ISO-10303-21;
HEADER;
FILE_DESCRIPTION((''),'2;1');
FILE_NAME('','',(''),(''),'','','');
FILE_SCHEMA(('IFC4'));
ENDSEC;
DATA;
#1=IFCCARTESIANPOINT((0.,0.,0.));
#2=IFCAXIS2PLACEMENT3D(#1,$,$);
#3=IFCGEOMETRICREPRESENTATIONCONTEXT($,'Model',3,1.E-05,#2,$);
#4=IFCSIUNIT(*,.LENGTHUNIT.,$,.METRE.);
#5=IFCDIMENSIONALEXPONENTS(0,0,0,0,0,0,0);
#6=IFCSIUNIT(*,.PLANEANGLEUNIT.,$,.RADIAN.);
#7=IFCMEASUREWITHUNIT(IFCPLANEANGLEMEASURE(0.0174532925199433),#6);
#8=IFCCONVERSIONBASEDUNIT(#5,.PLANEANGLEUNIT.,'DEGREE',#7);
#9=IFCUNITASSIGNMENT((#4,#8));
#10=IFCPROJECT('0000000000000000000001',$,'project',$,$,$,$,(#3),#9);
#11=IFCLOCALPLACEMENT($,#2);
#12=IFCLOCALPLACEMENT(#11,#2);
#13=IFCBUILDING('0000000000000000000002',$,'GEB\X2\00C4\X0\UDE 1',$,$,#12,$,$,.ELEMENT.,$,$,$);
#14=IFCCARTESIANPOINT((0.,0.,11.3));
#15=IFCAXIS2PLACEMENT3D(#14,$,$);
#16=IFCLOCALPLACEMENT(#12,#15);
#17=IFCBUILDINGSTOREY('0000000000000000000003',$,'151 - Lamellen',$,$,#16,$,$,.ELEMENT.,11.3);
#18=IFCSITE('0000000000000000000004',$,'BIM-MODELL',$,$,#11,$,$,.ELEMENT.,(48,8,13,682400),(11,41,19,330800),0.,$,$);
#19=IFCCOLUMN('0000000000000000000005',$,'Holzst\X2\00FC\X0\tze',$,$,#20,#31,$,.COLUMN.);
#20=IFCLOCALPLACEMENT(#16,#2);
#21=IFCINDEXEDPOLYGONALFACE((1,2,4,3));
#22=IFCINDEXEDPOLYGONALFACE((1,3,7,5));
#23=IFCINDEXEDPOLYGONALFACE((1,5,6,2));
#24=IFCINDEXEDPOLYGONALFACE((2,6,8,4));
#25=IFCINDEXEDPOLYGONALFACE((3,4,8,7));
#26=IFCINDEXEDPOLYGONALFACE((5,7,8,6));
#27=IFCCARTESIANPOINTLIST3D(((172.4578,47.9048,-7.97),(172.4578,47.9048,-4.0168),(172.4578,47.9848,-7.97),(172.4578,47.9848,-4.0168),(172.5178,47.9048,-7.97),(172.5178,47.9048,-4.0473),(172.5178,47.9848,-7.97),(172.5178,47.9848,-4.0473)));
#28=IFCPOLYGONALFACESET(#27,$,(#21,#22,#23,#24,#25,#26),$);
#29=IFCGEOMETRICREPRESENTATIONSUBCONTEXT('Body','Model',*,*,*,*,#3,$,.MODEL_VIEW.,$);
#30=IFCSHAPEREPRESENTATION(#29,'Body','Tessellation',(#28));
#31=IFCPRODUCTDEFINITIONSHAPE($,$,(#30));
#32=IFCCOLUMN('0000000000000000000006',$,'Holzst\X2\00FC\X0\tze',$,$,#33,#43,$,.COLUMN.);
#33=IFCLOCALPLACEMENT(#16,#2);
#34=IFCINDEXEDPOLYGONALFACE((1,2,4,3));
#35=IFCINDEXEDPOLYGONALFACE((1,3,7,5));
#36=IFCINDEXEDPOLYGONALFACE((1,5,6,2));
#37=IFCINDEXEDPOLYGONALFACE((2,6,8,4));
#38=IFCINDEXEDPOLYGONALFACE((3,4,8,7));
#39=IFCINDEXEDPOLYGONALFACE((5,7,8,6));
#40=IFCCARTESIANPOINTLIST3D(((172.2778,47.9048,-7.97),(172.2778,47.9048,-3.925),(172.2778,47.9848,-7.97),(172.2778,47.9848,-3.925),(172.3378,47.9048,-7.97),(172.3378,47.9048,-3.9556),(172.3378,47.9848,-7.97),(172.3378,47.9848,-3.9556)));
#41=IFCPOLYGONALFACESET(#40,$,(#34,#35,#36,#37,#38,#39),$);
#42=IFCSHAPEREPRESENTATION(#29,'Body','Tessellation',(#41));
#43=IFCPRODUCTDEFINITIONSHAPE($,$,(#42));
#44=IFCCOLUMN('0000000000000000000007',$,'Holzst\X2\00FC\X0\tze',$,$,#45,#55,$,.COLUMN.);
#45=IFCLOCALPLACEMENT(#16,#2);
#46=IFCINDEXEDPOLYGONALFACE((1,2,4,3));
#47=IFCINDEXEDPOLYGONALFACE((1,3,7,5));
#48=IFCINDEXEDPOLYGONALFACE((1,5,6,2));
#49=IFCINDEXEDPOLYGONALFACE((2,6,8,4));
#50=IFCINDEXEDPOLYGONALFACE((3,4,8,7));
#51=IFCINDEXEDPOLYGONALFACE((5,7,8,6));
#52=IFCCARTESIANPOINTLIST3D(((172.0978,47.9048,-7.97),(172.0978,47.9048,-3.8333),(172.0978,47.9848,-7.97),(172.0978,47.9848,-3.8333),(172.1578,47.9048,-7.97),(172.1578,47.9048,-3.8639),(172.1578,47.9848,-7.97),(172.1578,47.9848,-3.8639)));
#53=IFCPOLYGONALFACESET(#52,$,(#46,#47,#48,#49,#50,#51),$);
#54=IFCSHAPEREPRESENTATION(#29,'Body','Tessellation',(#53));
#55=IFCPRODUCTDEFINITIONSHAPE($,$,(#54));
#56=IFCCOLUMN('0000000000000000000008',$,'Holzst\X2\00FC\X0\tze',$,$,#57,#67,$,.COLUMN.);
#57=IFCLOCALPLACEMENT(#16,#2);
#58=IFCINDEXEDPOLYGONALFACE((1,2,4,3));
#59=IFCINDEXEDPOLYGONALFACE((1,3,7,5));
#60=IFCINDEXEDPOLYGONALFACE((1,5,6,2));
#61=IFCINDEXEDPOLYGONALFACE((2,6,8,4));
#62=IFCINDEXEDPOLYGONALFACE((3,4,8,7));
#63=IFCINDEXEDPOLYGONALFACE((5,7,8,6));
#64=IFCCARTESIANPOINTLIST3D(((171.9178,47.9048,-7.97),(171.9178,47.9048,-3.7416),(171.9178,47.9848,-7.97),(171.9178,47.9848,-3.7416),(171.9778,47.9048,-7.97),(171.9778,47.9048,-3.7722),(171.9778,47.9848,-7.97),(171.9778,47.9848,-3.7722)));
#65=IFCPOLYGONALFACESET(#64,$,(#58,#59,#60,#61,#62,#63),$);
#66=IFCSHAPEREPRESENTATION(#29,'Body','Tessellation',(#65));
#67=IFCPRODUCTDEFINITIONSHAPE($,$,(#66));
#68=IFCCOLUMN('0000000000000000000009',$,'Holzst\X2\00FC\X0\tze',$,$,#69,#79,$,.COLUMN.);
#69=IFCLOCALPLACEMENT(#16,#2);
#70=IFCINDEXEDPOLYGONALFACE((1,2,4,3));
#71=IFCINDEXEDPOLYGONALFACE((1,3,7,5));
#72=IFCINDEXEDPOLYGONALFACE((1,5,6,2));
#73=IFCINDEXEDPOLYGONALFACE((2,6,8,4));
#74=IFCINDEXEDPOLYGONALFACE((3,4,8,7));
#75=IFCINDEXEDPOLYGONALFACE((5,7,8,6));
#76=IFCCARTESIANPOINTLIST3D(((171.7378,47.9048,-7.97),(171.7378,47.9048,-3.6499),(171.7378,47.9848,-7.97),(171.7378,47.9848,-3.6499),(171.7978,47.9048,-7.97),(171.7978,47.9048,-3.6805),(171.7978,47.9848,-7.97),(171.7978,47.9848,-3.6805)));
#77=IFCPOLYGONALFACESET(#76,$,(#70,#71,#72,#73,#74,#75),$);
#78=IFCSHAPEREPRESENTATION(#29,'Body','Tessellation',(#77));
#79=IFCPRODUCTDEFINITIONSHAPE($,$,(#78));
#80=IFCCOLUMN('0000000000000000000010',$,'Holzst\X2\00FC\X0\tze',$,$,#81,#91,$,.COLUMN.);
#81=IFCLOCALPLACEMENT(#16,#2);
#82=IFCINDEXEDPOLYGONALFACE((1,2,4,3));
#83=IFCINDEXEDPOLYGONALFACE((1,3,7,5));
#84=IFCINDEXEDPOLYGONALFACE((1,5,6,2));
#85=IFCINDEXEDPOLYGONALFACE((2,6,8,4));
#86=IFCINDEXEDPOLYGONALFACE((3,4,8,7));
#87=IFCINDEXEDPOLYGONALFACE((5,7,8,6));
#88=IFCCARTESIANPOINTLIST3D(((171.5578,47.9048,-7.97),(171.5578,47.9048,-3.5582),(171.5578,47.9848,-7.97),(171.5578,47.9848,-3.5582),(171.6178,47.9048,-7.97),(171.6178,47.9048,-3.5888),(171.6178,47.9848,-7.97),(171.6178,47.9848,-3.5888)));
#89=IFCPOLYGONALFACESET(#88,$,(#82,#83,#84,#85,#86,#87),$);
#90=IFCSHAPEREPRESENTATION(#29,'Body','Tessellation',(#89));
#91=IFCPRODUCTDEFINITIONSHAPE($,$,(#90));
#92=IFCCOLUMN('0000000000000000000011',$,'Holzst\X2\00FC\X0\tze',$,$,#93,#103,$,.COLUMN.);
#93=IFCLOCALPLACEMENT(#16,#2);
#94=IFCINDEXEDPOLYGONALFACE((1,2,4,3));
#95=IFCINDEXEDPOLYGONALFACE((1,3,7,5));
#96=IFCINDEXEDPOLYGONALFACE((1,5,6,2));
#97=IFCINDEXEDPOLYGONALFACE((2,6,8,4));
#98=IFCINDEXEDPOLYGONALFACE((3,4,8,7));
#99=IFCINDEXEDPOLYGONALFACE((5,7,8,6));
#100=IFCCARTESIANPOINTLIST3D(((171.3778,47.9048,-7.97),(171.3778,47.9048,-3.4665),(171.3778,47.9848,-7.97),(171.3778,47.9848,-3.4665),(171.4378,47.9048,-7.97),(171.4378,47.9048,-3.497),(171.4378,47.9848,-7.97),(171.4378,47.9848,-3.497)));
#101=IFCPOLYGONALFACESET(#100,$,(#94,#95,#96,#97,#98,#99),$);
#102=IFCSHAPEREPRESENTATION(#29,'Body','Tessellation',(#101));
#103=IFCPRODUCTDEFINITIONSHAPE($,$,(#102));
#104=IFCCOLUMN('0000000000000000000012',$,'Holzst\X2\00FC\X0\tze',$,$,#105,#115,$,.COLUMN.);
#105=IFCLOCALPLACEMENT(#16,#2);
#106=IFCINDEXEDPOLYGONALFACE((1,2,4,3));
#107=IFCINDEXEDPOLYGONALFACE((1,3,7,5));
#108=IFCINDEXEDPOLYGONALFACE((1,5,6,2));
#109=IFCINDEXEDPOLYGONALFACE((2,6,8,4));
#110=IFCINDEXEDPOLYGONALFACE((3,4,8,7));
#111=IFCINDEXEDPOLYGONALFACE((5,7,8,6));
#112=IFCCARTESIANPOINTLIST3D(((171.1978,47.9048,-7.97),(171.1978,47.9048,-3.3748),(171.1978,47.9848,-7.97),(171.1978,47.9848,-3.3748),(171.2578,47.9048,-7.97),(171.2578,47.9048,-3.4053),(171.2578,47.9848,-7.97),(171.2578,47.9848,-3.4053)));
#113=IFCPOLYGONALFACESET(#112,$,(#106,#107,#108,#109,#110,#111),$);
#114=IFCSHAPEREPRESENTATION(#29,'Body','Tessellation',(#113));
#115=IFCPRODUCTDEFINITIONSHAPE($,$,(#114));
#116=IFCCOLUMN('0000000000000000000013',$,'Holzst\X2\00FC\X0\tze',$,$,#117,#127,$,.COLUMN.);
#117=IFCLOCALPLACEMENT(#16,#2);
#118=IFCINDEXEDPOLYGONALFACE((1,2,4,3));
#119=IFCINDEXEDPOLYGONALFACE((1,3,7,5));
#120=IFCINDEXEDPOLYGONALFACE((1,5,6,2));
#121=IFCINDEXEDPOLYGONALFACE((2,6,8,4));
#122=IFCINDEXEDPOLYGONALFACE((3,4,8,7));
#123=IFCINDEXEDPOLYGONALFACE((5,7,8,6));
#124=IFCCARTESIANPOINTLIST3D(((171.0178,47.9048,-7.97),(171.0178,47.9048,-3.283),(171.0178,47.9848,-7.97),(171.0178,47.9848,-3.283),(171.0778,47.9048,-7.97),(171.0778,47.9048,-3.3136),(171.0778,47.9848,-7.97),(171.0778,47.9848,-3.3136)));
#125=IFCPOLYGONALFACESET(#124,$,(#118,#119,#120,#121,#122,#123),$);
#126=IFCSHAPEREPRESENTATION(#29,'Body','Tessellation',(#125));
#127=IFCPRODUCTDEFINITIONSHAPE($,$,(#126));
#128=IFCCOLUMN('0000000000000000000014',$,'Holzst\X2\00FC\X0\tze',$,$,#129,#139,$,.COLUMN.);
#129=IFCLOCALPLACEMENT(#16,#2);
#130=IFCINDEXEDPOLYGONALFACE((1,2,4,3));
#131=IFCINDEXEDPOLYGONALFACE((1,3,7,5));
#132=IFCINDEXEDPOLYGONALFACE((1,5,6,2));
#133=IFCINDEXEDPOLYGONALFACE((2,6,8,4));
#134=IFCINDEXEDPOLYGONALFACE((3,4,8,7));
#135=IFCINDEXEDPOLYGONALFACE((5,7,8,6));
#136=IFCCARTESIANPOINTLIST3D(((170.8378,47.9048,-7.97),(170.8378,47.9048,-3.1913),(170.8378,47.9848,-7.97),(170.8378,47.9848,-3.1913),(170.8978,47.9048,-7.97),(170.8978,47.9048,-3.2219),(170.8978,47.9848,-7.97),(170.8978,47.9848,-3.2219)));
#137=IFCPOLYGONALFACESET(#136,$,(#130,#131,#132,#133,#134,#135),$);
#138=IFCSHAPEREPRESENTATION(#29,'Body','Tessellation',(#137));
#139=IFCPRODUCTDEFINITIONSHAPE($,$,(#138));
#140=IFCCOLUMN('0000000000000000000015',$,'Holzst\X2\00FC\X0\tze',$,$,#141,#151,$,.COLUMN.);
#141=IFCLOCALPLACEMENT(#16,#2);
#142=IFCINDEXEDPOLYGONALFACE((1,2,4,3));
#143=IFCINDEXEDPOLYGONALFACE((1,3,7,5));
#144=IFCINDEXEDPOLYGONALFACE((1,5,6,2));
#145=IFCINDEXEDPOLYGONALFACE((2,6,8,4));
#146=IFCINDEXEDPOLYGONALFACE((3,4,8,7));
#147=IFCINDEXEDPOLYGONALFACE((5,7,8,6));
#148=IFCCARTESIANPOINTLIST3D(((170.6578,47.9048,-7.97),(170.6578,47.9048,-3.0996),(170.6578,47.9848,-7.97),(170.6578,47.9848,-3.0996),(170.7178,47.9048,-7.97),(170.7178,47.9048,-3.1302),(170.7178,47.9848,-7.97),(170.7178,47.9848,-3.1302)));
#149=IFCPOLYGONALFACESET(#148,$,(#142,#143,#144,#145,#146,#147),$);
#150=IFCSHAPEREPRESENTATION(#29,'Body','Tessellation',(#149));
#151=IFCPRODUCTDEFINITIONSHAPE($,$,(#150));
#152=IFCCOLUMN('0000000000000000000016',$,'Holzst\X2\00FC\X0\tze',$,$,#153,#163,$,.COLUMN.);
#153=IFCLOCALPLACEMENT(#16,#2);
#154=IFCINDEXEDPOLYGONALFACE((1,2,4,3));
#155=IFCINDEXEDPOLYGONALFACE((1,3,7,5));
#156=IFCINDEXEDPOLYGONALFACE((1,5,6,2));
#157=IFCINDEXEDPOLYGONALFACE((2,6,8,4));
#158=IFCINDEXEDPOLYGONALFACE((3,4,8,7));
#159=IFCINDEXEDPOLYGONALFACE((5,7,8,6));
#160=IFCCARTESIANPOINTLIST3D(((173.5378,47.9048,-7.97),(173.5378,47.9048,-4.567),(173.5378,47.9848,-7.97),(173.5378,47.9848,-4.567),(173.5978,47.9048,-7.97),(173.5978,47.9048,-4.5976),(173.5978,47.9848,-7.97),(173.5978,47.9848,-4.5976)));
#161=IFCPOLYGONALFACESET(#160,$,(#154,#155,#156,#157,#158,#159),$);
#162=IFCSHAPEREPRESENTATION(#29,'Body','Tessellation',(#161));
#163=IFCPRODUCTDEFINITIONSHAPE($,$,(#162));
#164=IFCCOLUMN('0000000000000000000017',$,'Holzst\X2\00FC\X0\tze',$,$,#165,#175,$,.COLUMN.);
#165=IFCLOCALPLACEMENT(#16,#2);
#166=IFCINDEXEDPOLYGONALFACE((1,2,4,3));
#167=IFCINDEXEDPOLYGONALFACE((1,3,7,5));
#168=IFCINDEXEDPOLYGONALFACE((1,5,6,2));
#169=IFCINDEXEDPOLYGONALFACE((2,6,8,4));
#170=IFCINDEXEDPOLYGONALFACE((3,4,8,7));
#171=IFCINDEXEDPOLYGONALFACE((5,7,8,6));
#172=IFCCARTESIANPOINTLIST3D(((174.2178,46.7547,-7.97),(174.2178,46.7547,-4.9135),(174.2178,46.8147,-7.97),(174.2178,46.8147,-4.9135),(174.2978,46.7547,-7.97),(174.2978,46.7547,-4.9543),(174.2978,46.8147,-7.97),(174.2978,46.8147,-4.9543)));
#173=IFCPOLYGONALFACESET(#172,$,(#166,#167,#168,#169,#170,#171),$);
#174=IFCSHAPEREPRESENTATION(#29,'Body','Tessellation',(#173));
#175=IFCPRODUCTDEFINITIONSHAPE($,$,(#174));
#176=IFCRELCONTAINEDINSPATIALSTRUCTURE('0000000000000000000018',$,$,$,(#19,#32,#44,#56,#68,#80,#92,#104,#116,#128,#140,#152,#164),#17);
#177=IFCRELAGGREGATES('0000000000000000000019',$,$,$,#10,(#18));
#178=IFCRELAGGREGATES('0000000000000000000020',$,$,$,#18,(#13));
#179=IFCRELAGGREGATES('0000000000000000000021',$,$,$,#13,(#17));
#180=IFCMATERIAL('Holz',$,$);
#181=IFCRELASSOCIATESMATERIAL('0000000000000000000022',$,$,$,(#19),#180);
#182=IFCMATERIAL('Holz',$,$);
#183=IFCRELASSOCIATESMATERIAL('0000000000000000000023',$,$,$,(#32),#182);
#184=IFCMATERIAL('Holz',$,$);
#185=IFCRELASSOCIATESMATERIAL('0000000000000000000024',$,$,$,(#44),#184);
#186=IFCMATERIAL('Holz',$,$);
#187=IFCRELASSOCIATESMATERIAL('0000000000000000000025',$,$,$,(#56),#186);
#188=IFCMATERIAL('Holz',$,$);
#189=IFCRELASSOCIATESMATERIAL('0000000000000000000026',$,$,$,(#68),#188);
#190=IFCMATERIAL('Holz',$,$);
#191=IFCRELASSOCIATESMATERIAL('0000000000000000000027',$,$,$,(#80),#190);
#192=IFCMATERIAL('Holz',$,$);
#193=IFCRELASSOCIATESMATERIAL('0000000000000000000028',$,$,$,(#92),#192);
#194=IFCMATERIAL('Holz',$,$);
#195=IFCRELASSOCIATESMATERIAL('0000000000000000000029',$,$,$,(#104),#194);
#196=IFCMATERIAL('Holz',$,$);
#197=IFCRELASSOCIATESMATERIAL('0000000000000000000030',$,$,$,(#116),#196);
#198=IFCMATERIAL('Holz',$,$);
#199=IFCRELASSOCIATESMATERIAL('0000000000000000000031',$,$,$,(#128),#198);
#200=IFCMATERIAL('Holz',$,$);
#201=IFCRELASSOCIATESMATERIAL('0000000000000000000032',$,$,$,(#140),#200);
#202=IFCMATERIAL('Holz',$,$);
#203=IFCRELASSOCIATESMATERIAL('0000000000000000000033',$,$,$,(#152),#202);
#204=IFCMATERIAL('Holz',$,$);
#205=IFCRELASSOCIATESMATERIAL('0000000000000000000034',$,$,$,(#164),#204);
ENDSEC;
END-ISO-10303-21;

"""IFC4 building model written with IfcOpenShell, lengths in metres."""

from ifc_helpers import new_model, entity, si_unit, converted_unit, frame, frame_2d, origin, origin_with_axes, place, context, subcontext, project, spatial, rectangle, extrude, clip, halfspace, material, element, save


model = new_model("IFC4")

# Units and contexts
model_context = context("Model", 3, precision=1e-05, world=origin())
body_context = subcontext(model_context, "Body", "Model", "MODEL_VIEW")
ifc_project = project(units=[si_unit("LENGTHUNIT", "METRE"), converted_unit("PLANEANGLEUNIT", "DEGREE", entity("IfcPlaneAngleMeasure", 0.0174532925199433), si_unit("PLANEANGLEUNIT", "RADIAN"), dimensions=[0, 0, 0, 0, 0, 0, 0])], contexts=[model_context])

# Site, building, storey
site_placement = place(None, origin())
site = spatial("IfcSite", under=ifc_project, at=site_placement, Name="BIM-MODELL", CompositionType="ELEMENT", RefLatitude=(48, 8, 13, 682400), RefLongitude=(11, 41, 19, 330800), RefElevation=0.0)
building_placement = place(site_placement, origin())
building = spatial("IfcBuilding", under=site, at=building_placement, Name="GEBÄUDE 1", CompositionType="ELEMENT")
storey_placement = place(building_placement, frame((0.0, 0.0, 11.3)))
storey = spatial("IfcBuildingStorey", under=building, at=storey_placement, Name="151 - Lamellen", CompositionType="ELEMENT", Elevation=11.3)

# Columns
ifc_material_1 = material(Name="Holz")
column_1_placement = place(storey_placement, frame((172.4578, 47.9048, -7.97)))
element("IfcColumn", 1, at=column_1_placement, inside=storey, material=ifc_material_1, Name="Holzstütze", PredefinedType="COLUMN", context=body_context, shape_type="Clipping", body=[
    clip(extrude(rectangle(XDim=0.06, YDim=0.08, at=frame_2d((0.03, 0.04), x_axis=(1.0, 0.0))), origin_with_axes(), (0.0, 0.0, 1.0), 3.9532), halfspace(frame((0.03, 0.04, 3.938), z_axis=(-0.45399, 0.0, -0.891007), x_axis=(0.0, 1.0, 0.0)), True)),
])
ifc_material_2 = material(Name="Holz")
column_2_placement = place(storey_placement, frame((172.2778, 47.9048, -7.97)))
element("IfcColumn", 2, at=column_2_placement, inside=storey, material=ifc_material_2, Name="Holzstütze", PredefinedType="COLUMN", context=body_context, shape_type="Clipping", body=[
    clip(extrude(rectangle(XDim=0.06, YDim=0.08, at=frame_2d((0.03, 0.04), x_axis=(1.0, 0.0))), origin_with_axes(), (0.0, 0.0, 1.0), 4.045), halfspace(frame((0.03, 0.04, 4.0297), z_axis=(-0.45399, 0.0, -0.891007), x_axis=(0.0, 1.0, 0.0)), True)),
])
ifc_material_3 = material(Name="Holz")
column_3_placement = place(storey_placement, frame((172.0978, 47.9048, -7.97)))
element("IfcColumn", 3, at=column_3_placement, inside=storey, material=ifc_material_3, Name="Holzstütze", PredefinedType="COLUMN", context=body_context, shape_type="Clipping", body=[
    clip(extrude(rectangle(XDim=0.06, YDim=0.08, at=frame_2d((0.03, 0.04), x_axis=(1.0, 0.0))), origin_with_axes(), (0.0, 0.0, 1.0), 4.1367), halfspace(frame((0.03, 0.04, 4.1214), z_axis=(-0.45399, 0.0, -0.891007), x_axis=(0.0, 1.0, 0.0)), True)),
])
ifc_material_4 = material(Name="Holz")
column_4_placement = place(storey_placement, frame((171.9178, 47.9048, -7.97)))
element("IfcColumn", 4, at=column_4_placement, inside=storey, material=ifc_material_4, Name="Holzstütze", PredefinedType="COLUMN", context=body_context, shape_type="Clipping", body=[
    clip(extrude(rectangle(XDim=0.06, YDim=0.08, at=frame_2d((0.03, 0.04), x_axis=(1.0, 0.0))), origin_with_axes(), (0.0, 0.0, 1.0), 4.2284), halfspace(frame((0.03, 0.04, 4.2131), z_axis=(-0.45399, 0.0, -0.891007), x_axis=(0.0, 1.0, 0.0)), True)),
])
ifc_material_5 = material(Name="Holz")
column_5_placement = place(storey_placement, frame((171.7378, 47.9048, -7.97)))
element("IfcColumn", 5, at=column_5_placement, inside=storey, material=ifc_material_5, Name="Holzstütze", PredefinedType="COLUMN", context=body_context, shape_type="Clipping", body=[
    clip(extrude(rectangle(XDim=0.06, YDim=0.08, at=frame_2d((0.03, 0.04), x_axis=(1.0, 0.0))), origin_with_axes(), (0.0, 0.0, 1.0), 4.3201), halfspace(frame((0.03, 0.04, 4.3048), z_axis=(-0.45399, 0.0, -0.891007), x_axis=(0.0, 1.0, 0.0)), True)),
])
ifc_material_6 = material(Name="Holz")
column_6_placement = place(storey_placement, frame((171.5578, 47.9048, -7.97)))
element("IfcColumn", 6, at=column_6_placement, inside=storey, material=ifc_material_6, Name="Holzstütze", PredefinedType="COLUMN", context=body_context, shape_type="Clipping", body=[
    clip(extrude(rectangle(XDim=0.06, YDim=0.08, at=frame_2d((0.03, 0.04), x_axis=(1.0, 0.0))), origin_with_axes(), (0.0, 0.0, 1.0), 4.4118), halfspace(frame((0.03, 0.04, 4.3965), z_axis=(-0.45399, 0.0, -0.891007), x_axis=(0.0, 1.0, 0.0)), True)),
])
ifc_material_7 = material(Name="Holz")
column_7_placement = place(storey_placement, frame((171.3778, 47.9048, -7.97)))
element("IfcColumn", 7, at=column_7_placement, inside=storey, material=ifc_material_7, Name="Holzstütze", PredefinedType="COLUMN", context=body_context, shape_type="Clipping", body=[
    clip(extrude(rectangle(XDim=0.06, YDim=0.08, at=frame_2d((0.03, 0.04), x_axis=(1.0, 0.0))), origin_with_axes(), (0.0, 0.0, 1.0), 4.5035), halfspace(frame((0.03, 0.04, 4.4882), z_axis=(-0.45399, 0.0, -0.891007), x_axis=(0.0, 1.0, 0.0)), True)),
])
ifc_material_8 = material(Name="Holz")
column_8_placement = place(storey_placement, frame((171.1978, 47.9048, -7.97)))
element("IfcColumn", 8, at=column_8_placement, inside=storey, material=ifc_material_8, Name="Holzstütze", PredefinedType="COLUMN", context=body_context, shape_type="Clipping", body=[
    clip(extrude(rectangle(XDim=0.06, YDim=0.08, at=frame_2d((0.03, 0.04), x_axis=(1.0, 0.0))), origin_with_axes(), (0.0, 0.0, 1.0), 4.5952), halfspace(frame((0.03, 0.04, 4.58), z_axis=(-0.45399, 0.0, -0.891007), x_axis=(0.0, 1.0, 0.0)), True)),
])
ifc_material_9 = material(Name="Holz")
column_9_placement = place(storey_placement, frame((171.0178, 47.9048, -7.97)))
element("IfcColumn", 9, at=column_9_placement, inside=storey, material=ifc_material_9, Name="Holzstütze", PredefinedType="COLUMN", context=body_context, shape_type="Clipping", body=[
    clip(extrude(rectangle(XDim=0.06, YDim=0.08, at=frame_2d((0.03, 0.04), x_axis=(1.0, 0.0))), origin_with_axes(), (0.0, 0.0, 1.0), 4.687), halfspace(frame((0.03, 0.04, 4.6717), z_axis=(-0.45399, 0.0, -0.891007), x_axis=(0.0, 1.0, 0.0)), True)),
])
ifc_material_10 = material(Name="Holz")
column_10_placement = place(storey_placement, frame((170.8378, 47.9048, -7.97)))
element("IfcColumn", 10, at=column_10_placement, inside=storey, material=ifc_material_10, Name="Holzstütze", PredefinedType="COLUMN", context=body_context, shape_type="Clipping", body=[
    clip(extrude(rectangle(XDim=0.06, YDim=0.08, at=frame_2d((0.03, 0.04), x_axis=(1.0, 0.0))), origin_with_axes(), (0.0, 0.0, 1.0), 4.7787), halfspace(frame((0.03, 0.04, 4.7634), z_axis=(-0.45399, 0.0, -0.891007), x_axis=(0.0, 1.0, 0.0)), True)),
])
ifc_material_11 = material(Name="Holz")
column_11_placement = place(storey_placement, frame((170.6578, 47.9048, -7.97)))
element("IfcColumn", 11, at=column_11_placement, inside=storey, material=ifc_material_11, Name="Holzstütze", PredefinedType="COLUMN", context=body_context, shape_type="Clipping", body=[
    clip(extrude(rectangle(XDim=0.06, YDim=0.08, at=frame_2d((0.03, 0.04), x_axis=(1.0, 0.0))), origin_with_axes(), (0.0, 0.0, 1.0), 4.8704), halfspace(frame((0.03, 0.04, 4.8551), z_axis=(-0.45399, 0.0, -0.891007), x_axis=(0.0, 1.0, 0.0)), True)),
])
ifc_material_12 = material(Name="Holz")
column_12_placement = place(storey_placement, frame((173.5378, 47.9048, -7.97)))
element("IfcColumn", 12, at=column_12_placement, inside=storey, material=ifc_material_12, Name="Holzstütze", PredefinedType="COLUMN", context=body_context, shape_type="Clipping", body=[
    clip(extrude(rectangle(XDim=0.06, YDim=0.08, at=frame_2d((0.03, 0.04), x_axis=(1.0, 0.0))), origin_with_axes(), (0.0, 0.0, 1.0), 3.403), halfspace(frame((0.03, 0.04, 3.3877), z_axis=(-0.45399, 0.0, -0.891007), x_axis=(0.0, 1.0, 0.0)), True)),
])
ifc_material_13 = material(Name="Holz")
column_13_placement = place(storey_placement, frame((174.2978, 46.7547, -7.97)))
element("IfcColumn", 13, at=column_13_placement, inside=storey, material=ifc_material_13, Name="Holzstütze", PredefinedType="COLUMN", context=body_context, shape_type="Clipping", body=[
    clip(extrude(rectangle(XDim=0.06, YDim=0.08, at=frame_2d((-0.04, 0.03), x_axis=(0.0, 1.0))), origin_with_axes(), (0.0, 0.0, 1.0), 3.0565), halfspace(frame((-0.04, 0.03, 3.0361), z_axis=(-0.45399, 0.0, -0.891007), x_axis=(0.891007, 0.0, -0.45399)), True)),
])

save(model, "model.ifc")
